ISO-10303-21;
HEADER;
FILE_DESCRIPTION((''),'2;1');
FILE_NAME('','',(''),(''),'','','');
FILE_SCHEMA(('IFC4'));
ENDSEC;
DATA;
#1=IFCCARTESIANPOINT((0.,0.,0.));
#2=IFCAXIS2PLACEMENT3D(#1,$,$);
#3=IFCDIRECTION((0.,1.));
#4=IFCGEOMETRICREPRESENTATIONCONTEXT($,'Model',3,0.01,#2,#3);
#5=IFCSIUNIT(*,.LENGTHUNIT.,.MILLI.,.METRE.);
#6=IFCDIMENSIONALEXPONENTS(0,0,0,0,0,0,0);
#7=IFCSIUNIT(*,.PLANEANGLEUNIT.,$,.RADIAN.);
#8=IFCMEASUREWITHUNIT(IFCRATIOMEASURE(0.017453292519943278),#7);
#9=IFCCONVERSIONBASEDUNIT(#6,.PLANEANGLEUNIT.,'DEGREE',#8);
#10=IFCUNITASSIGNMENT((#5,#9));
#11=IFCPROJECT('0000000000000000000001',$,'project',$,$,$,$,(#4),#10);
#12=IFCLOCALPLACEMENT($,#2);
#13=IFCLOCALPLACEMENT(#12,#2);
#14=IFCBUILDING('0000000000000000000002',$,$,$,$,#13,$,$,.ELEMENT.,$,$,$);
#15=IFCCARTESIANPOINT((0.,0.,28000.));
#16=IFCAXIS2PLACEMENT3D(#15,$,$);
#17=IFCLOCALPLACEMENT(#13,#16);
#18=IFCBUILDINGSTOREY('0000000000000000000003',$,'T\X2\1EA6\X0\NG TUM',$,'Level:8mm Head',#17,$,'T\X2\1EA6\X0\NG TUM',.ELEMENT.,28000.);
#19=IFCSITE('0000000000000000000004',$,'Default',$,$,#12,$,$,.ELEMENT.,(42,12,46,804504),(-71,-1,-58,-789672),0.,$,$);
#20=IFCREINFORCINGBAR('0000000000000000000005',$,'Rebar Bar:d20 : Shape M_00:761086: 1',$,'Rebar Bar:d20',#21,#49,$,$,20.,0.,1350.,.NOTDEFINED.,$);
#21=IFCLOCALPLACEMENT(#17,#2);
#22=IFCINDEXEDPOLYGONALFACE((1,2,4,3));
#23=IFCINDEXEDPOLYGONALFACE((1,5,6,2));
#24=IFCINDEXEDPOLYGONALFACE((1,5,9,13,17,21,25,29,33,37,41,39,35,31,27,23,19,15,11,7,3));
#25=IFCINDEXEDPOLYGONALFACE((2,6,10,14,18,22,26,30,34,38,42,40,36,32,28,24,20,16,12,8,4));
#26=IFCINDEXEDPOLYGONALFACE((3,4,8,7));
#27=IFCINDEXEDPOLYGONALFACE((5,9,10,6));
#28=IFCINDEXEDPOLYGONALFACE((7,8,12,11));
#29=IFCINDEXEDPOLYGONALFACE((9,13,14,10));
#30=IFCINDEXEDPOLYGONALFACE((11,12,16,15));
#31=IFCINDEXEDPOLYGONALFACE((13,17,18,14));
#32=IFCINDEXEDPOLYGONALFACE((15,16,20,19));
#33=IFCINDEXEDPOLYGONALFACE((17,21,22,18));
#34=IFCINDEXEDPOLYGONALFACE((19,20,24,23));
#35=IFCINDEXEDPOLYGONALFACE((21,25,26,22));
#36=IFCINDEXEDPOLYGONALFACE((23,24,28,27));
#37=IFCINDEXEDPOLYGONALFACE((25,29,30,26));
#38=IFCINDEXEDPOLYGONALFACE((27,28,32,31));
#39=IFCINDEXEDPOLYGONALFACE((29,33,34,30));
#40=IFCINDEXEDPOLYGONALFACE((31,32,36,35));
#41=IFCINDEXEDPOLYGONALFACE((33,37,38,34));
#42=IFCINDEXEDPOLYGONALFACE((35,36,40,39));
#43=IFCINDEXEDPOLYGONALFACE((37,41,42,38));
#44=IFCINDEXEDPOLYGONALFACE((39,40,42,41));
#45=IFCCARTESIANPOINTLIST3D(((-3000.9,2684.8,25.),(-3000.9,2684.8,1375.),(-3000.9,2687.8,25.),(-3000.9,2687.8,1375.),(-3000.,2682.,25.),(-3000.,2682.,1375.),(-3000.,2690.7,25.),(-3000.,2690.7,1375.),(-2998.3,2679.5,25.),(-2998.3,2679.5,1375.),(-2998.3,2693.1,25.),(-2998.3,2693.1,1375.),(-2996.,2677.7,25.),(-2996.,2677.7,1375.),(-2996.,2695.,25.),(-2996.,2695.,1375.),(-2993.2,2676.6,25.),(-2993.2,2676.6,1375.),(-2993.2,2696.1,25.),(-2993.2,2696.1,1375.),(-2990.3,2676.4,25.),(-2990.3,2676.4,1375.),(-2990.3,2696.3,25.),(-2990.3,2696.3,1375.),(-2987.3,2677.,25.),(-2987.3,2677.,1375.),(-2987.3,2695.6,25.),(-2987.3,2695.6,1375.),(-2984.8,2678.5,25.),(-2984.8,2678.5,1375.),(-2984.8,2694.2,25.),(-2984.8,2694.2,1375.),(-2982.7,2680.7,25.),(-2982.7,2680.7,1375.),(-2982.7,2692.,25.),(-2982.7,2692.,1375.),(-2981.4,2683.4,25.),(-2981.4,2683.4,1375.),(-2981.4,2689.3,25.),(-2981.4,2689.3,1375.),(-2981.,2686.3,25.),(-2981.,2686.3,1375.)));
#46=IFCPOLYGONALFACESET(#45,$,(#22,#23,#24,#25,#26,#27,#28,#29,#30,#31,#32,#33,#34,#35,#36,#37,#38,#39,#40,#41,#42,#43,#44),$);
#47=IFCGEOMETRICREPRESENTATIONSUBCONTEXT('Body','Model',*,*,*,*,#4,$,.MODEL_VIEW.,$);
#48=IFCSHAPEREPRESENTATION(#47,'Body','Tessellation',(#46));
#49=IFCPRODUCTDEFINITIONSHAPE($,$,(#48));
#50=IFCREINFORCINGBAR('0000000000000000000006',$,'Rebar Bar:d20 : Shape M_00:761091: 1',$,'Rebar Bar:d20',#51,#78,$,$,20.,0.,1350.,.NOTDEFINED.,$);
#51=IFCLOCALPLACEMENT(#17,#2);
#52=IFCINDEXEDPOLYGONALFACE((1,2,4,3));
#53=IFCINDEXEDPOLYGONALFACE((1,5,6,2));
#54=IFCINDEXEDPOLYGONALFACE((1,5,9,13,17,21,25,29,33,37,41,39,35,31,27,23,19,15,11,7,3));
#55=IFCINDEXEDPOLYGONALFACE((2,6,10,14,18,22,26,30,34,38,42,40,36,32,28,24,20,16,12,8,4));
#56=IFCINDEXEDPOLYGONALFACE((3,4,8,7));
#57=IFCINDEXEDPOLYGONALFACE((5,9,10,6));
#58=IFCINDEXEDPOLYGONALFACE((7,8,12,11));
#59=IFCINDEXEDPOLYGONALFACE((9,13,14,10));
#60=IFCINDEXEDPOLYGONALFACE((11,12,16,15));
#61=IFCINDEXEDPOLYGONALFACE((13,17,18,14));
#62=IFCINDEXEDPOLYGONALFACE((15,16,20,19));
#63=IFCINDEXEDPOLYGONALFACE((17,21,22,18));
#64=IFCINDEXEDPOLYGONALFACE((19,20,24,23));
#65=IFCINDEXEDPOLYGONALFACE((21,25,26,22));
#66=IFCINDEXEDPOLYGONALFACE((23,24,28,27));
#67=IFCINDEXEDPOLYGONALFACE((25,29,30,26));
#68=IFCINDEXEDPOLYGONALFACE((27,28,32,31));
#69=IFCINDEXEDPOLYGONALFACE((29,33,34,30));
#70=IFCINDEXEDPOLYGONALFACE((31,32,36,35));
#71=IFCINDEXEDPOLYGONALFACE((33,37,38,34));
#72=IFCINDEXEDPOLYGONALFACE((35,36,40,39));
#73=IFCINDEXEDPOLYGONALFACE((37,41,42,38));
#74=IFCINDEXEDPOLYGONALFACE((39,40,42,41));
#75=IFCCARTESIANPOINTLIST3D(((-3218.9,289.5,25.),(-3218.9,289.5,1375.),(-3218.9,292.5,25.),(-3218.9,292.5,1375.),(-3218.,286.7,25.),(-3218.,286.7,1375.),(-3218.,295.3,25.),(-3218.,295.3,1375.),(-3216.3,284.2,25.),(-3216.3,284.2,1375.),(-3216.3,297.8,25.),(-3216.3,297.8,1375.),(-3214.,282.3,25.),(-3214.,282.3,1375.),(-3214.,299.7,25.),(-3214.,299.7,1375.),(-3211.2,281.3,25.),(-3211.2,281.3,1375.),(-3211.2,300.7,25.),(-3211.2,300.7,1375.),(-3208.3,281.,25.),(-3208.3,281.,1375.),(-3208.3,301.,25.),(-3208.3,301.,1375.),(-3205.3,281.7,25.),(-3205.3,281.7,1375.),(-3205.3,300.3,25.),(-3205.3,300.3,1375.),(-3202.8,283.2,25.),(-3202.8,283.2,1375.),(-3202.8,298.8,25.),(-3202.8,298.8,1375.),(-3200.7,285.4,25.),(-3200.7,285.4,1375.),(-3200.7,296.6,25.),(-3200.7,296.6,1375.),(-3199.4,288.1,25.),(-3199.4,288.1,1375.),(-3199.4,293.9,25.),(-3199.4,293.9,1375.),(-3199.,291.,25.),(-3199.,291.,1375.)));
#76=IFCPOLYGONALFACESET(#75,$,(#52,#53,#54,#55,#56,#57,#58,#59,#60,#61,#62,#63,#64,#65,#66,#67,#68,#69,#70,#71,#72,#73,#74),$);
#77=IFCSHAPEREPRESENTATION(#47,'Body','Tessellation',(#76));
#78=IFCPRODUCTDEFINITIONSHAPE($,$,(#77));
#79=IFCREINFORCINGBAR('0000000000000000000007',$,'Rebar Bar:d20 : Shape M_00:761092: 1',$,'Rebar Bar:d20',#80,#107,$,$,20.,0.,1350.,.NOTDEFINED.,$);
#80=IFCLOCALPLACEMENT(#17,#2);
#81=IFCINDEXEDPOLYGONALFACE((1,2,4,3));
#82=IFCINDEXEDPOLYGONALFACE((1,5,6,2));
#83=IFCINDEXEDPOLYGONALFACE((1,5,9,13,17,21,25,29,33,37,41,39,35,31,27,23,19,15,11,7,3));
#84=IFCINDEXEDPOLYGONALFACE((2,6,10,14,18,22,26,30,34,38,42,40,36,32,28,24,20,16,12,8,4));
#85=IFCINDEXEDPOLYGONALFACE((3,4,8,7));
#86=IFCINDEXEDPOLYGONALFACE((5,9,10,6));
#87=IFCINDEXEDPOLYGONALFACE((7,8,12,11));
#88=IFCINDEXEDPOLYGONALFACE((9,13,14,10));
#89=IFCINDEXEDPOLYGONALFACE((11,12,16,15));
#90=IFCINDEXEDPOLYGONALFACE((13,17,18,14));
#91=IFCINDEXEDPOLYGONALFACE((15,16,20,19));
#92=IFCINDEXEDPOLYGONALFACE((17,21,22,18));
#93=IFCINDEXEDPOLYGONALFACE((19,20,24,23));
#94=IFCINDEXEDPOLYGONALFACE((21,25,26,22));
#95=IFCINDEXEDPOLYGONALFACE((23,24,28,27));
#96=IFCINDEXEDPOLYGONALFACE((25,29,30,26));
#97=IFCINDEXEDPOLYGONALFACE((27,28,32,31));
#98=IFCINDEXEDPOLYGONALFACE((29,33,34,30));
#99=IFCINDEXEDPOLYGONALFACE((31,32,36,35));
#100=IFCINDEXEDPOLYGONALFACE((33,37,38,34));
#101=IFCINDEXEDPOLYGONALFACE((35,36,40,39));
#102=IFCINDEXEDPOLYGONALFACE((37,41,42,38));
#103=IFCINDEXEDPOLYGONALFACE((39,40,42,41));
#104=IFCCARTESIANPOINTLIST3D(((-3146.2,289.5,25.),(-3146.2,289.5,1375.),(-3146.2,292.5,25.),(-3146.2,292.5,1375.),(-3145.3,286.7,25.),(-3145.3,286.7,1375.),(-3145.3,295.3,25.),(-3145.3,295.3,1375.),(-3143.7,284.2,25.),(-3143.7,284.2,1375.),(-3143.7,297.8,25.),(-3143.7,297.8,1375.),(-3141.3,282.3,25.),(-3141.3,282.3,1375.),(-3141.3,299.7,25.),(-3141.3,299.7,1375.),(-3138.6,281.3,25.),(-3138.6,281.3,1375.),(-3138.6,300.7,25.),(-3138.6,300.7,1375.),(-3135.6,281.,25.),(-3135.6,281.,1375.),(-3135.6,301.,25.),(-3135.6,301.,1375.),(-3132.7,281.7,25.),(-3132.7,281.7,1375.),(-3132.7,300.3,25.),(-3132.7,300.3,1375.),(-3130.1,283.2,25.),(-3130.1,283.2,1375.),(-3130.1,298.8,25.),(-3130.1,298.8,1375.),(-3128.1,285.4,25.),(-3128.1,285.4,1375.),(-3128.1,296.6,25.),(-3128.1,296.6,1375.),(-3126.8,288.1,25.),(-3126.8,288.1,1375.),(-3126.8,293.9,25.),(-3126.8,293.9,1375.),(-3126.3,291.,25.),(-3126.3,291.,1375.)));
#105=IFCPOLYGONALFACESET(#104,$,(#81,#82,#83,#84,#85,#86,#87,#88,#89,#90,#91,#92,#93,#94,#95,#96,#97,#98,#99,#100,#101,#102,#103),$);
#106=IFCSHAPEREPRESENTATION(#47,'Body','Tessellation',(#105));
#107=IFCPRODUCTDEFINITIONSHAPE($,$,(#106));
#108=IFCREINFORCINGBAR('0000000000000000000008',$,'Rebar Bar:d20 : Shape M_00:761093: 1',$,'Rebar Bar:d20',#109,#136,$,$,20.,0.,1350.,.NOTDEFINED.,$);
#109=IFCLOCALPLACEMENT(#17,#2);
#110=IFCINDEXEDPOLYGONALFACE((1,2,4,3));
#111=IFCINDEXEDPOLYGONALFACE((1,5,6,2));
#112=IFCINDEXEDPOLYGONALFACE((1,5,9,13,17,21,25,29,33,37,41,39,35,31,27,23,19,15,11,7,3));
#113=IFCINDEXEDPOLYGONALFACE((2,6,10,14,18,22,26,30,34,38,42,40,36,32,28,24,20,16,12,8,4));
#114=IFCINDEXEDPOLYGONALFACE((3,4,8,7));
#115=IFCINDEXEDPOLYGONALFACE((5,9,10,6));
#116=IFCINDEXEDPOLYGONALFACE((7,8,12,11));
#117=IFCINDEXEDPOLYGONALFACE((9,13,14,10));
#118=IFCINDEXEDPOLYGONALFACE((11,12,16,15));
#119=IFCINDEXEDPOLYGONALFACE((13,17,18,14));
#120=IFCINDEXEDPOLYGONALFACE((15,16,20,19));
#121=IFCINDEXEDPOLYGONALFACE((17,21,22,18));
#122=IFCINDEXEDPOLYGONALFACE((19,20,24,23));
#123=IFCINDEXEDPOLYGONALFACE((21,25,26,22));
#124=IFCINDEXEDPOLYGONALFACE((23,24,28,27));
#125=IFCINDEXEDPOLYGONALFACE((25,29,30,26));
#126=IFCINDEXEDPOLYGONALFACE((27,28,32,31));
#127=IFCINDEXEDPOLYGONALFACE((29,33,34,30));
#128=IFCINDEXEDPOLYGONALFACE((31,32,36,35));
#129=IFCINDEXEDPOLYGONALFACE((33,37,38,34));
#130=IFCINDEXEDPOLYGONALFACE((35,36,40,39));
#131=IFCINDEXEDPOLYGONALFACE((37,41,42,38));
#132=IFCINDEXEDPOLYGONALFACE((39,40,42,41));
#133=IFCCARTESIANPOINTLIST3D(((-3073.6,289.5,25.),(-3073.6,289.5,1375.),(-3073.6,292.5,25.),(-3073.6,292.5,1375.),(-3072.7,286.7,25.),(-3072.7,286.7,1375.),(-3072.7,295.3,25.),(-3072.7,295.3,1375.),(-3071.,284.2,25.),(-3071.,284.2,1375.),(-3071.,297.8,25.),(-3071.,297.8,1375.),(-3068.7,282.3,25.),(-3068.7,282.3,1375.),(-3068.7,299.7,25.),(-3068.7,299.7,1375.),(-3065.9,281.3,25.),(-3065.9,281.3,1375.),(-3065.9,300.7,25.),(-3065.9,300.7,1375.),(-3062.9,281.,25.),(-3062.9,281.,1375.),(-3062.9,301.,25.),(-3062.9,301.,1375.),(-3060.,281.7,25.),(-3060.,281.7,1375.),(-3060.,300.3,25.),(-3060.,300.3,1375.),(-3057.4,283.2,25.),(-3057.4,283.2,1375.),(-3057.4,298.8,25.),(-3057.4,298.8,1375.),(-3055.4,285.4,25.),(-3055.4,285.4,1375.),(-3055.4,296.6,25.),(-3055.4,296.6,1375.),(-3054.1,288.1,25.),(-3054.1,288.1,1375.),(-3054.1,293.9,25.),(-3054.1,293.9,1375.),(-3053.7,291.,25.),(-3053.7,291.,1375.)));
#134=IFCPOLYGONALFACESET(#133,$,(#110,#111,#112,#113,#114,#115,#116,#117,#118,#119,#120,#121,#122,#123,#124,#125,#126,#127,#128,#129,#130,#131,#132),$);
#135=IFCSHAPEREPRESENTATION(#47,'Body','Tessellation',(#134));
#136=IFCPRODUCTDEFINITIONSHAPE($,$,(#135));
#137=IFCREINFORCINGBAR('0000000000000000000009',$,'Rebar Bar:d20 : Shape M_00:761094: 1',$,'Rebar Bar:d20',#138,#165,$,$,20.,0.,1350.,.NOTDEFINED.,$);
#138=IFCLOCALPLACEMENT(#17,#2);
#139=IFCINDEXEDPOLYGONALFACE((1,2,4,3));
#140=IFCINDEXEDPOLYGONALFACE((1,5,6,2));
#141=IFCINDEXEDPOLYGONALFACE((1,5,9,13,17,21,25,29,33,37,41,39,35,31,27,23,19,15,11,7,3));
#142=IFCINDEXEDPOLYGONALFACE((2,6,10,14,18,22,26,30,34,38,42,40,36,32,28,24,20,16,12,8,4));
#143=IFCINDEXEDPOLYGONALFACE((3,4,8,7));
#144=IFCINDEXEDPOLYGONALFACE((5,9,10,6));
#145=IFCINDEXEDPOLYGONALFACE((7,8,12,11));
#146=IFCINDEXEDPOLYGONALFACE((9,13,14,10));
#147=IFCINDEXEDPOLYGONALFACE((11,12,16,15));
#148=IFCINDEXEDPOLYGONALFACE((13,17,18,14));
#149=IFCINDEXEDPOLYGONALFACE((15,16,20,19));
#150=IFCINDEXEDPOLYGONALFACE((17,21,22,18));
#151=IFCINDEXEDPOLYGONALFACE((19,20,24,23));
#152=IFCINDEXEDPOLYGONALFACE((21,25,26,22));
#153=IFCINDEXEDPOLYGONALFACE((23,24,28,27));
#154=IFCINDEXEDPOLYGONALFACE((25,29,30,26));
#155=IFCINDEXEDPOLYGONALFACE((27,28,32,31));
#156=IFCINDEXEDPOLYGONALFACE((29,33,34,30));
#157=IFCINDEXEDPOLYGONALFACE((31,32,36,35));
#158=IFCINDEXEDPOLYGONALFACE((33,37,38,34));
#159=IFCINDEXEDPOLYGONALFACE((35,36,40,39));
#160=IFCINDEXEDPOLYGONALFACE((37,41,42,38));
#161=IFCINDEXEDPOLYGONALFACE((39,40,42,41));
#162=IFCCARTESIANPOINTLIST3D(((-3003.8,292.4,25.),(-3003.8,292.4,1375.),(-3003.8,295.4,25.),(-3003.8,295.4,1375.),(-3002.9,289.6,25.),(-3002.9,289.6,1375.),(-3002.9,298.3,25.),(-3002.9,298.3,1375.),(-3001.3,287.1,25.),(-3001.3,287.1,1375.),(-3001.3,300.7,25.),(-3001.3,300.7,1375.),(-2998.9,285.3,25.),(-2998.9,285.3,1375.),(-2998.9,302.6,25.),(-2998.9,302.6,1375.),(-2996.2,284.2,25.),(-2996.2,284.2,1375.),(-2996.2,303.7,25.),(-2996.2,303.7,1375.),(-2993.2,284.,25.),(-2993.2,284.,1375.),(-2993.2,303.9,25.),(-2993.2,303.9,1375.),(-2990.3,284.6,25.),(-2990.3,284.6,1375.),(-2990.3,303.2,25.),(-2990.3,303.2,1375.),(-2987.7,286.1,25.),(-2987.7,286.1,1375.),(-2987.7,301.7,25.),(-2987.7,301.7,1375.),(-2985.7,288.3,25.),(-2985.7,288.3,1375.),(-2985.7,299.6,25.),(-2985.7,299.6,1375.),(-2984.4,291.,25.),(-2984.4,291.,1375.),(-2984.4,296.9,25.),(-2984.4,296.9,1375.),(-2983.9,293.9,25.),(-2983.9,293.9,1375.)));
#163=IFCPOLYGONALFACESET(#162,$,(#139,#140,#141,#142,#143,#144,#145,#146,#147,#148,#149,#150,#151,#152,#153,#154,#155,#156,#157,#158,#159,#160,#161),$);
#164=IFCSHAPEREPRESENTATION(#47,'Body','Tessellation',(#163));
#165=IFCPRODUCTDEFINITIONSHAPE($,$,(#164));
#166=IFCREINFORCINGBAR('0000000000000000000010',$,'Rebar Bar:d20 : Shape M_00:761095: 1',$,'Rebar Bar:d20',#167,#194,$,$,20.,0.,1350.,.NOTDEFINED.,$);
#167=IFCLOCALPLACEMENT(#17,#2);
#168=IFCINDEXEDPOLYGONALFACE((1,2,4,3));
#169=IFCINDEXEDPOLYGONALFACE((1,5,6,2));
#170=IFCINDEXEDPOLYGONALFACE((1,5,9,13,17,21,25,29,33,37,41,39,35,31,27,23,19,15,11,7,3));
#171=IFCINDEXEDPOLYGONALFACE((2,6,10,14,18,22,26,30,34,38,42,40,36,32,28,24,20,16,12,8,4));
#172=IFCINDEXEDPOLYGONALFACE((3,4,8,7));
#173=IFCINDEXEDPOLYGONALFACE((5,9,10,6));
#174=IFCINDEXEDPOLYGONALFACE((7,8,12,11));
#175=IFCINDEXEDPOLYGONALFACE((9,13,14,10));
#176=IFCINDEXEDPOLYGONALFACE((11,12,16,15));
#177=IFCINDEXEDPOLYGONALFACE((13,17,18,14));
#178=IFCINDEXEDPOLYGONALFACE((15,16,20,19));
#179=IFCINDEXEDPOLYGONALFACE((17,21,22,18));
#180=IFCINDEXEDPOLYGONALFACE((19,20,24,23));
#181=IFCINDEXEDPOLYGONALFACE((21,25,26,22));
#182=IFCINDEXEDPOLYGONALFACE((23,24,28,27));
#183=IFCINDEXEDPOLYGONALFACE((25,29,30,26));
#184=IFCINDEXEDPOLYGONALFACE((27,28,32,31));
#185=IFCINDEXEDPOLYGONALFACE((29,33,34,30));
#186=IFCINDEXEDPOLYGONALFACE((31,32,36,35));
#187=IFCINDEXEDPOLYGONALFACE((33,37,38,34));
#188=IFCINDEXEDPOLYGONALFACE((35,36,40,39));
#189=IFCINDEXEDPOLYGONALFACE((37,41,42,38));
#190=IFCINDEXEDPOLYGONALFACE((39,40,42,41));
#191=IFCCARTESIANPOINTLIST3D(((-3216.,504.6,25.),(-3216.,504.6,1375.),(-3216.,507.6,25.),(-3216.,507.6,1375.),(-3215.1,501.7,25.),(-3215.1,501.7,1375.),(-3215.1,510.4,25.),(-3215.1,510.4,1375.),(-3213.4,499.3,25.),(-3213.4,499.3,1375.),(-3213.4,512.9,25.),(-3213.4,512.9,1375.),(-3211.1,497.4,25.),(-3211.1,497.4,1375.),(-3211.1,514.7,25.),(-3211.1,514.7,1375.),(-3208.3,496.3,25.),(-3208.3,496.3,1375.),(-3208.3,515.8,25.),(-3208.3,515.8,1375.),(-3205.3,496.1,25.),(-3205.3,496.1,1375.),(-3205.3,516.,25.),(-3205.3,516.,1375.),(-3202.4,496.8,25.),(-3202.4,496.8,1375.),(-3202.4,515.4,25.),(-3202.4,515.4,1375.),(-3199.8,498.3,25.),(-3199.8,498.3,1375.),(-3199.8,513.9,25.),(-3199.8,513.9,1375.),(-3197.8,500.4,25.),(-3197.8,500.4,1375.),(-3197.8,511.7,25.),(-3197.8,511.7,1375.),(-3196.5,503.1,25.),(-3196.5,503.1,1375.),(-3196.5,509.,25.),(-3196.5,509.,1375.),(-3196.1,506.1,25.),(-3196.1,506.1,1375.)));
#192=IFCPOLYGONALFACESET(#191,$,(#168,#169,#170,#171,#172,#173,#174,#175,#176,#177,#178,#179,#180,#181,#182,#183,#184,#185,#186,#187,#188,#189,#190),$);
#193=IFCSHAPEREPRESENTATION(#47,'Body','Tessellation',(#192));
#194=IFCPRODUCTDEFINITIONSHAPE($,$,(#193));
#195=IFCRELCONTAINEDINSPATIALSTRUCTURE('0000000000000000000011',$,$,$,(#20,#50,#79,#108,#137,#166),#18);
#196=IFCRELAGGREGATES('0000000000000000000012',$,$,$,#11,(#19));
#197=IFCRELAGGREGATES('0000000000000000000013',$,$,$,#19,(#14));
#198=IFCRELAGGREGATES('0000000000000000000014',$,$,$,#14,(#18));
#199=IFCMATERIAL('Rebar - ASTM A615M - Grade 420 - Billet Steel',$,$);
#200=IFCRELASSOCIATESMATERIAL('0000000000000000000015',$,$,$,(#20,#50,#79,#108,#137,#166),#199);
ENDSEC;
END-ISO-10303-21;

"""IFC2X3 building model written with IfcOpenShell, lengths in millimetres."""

from ifc_helpers import new_model, entity, si_unit, converted_unit, direction, frame, origin, place, context, subcontext, project, spatial, material, element, save


model = new_model("IFC2X3")

# Units and contexts
model_context = context("Model", 3, precision=0.01, world=origin(), true_north=direction((0.0, 1.0)))
body_context = subcontext(model_context, "Body", "Model", "MODEL_VIEW")
ifc_project = project(units=[si_unit("LENGTHUNIT", "METRE", prefix="MILLI"), converted_unit("PLANEANGLEUNIT", "DEGREE", entity("IfcRatioMeasure", 0.017453292519943278), si_unit("PLANEANGLEUNIT", "RADIAN"), dimensions=[0, 0, 0, 0, 0, 0, 0])], contexts=[model_context])

# Site, building, storey
site_placement = place(None, origin())
site = spatial("IfcSite", under=ifc_project, at=site_placement, Name="Default", CompositionType="ELEMENT", RefLatitude=(42, 12, 46, 804504), RefLongitude=(-71, -1, -58, -789672), RefElevation=0.0)
building_placement = place(site_placement, origin())
building = spatial("IfcBuilding", under=site, at=building_placement, CompositionType="ELEMENT")
storey_placement = place(building_placement, frame((0.0, 0.0, 28000.0)))
storey = spatial("IfcBuildingStorey", under=building, at=storey_placement, Name="TẦNG TUM", ObjectType="Level:8mm Head", LongName="TẦNG TUM", CompositionType="ELEMENT", Elevation=28000.0)

# Reinforcing bars
ifc_material = material(Name="Rebar - ASTM A615M - Grade 420 - Billet Steel")
reinforcing_bar_1_placement = place(storey_placement, origin())
element("IfcReinforcingBar", 1, at=reinforcing_bar_1_placement, inside=storey, material=ifc_material, Name="Rebar Bar:d20 : Shape M_00:761086: 1", ObjectType="Rebar Bar:d20", BarLength=1350.0, BarRole="NOTDEFINED", CrossSectionArea=0.0, NominalDiameter=20.0, context=body_context, shape_type="AdvancedSweptSolid", body=[
    entity("IfcSweptDiskSolid", entity("IfcCompositeCurve", [entity("IfcCompositeCurveSegment", "CONTINUOUS", True, entity("IfcPolyline", [entity("IfcCartesianPoint", [-2991.0, 2686.3, 25.0]), entity("IfcCartesianPoint", [-2991.0, 2686.3, 1375.0])]))], False), 10.0, None, 0.0, 1.0),
])
reinforcing_bar_2_placement = place(storey_placement, origin())
element("IfcReinforcingBar", 2, at=reinforcing_bar_2_placement, inside=storey, material=ifc_material, Name="Rebar Bar:d20 : Shape M_00:761091: 1", ObjectType="Rebar Bar:d20", BarLength=1350.0, BarRole="NOTDEFINED", CrossSectionArea=0.0, NominalDiameter=20.0, context=body_context, shape_type="AdvancedSweptSolid", body=[
    entity("IfcSweptDiskSolid", entity("IfcCompositeCurve", [entity("IfcCompositeCurveSegment", "CONTINUOUS", True, entity("IfcPolyline", [entity("IfcCartesianPoint", [-3209.0, 291.0, 25.0]), entity("IfcCartesianPoint", [-3209.0, 291.0, 1375.0])]))], False), 10.0, None, 0.0, 1.0),
])
reinforcing_bar_3_placement = place(storey_placement, origin())
element("IfcReinforcingBar", 3, at=reinforcing_bar_3_placement, inside=storey, material=ifc_material, Name="Rebar Bar:d20 : Shape M_00:761092: 1", ObjectType="Rebar Bar:d20", BarLength=1350.0, BarRole="NOTDEFINED", CrossSectionArea=0.0, NominalDiameter=20.0, context=body_context, shape_type="AdvancedSweptSolid", body=[
    entity("IfcSweptDiskSolid", entity("IfcCompositeCurve", [entity("IfcCompositeCurveSegment", "CONTINUOUS", True, entity("IfcPolyline", [entity("IfcCartesianPoint", [-3136.3, 291.0, 25.0]), entity("IfcCartesianPoint", [-3136.3, 291.0, 1375.0])]))], False), 10.0, None, 0.0, 1.0),
])
reinforcing_bar_4_placement = place(storey_placement, origin())
element("IfcReinforcingBar", 4, at=reinforcing_bar_4_placement, inside=storey, material=ifc_material, Name="Rebar Bar:d20 : Shape M_00:761093: 1", ObjectType="Rebar Bar:d20", BarLength=1350.0, BarRole="NOTDEFINED", CrossSectionArea=0.0, NominalDiameter=20.0, context=body_context, shape_type="AdvancedSweptSolid", body=[
    entity("IfcSweptDiskSolid", entity("IfcCompositeCurve", [entity("IfcCompositeCurveSegment", "CONTINUOUS", True, entity("IfcPolyline", [entity("IfcCartesianPoint", [-3063.7, 291.0, 25.0]), entity("IfcCartesianPoint", [-3063.7, 291.0, 1375.0])]))], False), 10.0, None, 0.0, 1.0),
])
reinforcing_bar_5_placement = place(storey_placement, origin())
element("IfcReinforcingBar", 5, at=reinforcing_bar_5_placement, inside=storey, material=ifc_material, Name="Rebar Bar:d20 : Shape M_00:761094: 1", ObjectType="Rebar Bar:d20", BarLength=1350.0, BarRole="NOTDEFINED", CrossSectionArea=0.0, NominalDiameter=20.0, context=body_context, shape_type="AdvancedSweptSolid", body=[
    entity("IfcSweptDiskSolid", entity("IfcCompositeCurve", [entity("IfcCompositeCurveSegment", "CONTINUOUS", True, entity("IfcPolyline", [entity("IfcCartesianPoint", [-2993.9, 293.9, 25.0]), entity("IfcCartesianPoint", [-2993.9, 293.9, 1375.0])]))], False), 10.0, None, 0.0, 1.0),
])
reinforcing_bar_6_placement = place(storey_placement, origin())
element("IfcReinforcingBar", 6, at=reinforcing_bar_6_placement, inside=storey, material=ifc_material, Name="Rebar Bar:d20 : Shape M_00:761095: 1", ObjectType="Rebar Bar:d20", BarLength=1350.0, BarRole="NOTDEFINED", CrossSectionArea=0.0, NominalDiameter=20.0, context=body_context, shape_type="AdvancedSweptSolid", body=[
    entity("IfcSweptDiskSolid", entity("IfcCompositeCurve", [entity("IfcCompositeCurveSegment", "CONTINUOUS", True, entity("IfcPolyline", [entity("IfcCartesianPoint", [-3206.1, 506.1, 25.0]), entity("IfcCartesianPoint", [-3206.1, 506.1, 1375.0])]))], False), 10.0, None, 0.0, 1.0),
])

save(model, "model.ifc")
